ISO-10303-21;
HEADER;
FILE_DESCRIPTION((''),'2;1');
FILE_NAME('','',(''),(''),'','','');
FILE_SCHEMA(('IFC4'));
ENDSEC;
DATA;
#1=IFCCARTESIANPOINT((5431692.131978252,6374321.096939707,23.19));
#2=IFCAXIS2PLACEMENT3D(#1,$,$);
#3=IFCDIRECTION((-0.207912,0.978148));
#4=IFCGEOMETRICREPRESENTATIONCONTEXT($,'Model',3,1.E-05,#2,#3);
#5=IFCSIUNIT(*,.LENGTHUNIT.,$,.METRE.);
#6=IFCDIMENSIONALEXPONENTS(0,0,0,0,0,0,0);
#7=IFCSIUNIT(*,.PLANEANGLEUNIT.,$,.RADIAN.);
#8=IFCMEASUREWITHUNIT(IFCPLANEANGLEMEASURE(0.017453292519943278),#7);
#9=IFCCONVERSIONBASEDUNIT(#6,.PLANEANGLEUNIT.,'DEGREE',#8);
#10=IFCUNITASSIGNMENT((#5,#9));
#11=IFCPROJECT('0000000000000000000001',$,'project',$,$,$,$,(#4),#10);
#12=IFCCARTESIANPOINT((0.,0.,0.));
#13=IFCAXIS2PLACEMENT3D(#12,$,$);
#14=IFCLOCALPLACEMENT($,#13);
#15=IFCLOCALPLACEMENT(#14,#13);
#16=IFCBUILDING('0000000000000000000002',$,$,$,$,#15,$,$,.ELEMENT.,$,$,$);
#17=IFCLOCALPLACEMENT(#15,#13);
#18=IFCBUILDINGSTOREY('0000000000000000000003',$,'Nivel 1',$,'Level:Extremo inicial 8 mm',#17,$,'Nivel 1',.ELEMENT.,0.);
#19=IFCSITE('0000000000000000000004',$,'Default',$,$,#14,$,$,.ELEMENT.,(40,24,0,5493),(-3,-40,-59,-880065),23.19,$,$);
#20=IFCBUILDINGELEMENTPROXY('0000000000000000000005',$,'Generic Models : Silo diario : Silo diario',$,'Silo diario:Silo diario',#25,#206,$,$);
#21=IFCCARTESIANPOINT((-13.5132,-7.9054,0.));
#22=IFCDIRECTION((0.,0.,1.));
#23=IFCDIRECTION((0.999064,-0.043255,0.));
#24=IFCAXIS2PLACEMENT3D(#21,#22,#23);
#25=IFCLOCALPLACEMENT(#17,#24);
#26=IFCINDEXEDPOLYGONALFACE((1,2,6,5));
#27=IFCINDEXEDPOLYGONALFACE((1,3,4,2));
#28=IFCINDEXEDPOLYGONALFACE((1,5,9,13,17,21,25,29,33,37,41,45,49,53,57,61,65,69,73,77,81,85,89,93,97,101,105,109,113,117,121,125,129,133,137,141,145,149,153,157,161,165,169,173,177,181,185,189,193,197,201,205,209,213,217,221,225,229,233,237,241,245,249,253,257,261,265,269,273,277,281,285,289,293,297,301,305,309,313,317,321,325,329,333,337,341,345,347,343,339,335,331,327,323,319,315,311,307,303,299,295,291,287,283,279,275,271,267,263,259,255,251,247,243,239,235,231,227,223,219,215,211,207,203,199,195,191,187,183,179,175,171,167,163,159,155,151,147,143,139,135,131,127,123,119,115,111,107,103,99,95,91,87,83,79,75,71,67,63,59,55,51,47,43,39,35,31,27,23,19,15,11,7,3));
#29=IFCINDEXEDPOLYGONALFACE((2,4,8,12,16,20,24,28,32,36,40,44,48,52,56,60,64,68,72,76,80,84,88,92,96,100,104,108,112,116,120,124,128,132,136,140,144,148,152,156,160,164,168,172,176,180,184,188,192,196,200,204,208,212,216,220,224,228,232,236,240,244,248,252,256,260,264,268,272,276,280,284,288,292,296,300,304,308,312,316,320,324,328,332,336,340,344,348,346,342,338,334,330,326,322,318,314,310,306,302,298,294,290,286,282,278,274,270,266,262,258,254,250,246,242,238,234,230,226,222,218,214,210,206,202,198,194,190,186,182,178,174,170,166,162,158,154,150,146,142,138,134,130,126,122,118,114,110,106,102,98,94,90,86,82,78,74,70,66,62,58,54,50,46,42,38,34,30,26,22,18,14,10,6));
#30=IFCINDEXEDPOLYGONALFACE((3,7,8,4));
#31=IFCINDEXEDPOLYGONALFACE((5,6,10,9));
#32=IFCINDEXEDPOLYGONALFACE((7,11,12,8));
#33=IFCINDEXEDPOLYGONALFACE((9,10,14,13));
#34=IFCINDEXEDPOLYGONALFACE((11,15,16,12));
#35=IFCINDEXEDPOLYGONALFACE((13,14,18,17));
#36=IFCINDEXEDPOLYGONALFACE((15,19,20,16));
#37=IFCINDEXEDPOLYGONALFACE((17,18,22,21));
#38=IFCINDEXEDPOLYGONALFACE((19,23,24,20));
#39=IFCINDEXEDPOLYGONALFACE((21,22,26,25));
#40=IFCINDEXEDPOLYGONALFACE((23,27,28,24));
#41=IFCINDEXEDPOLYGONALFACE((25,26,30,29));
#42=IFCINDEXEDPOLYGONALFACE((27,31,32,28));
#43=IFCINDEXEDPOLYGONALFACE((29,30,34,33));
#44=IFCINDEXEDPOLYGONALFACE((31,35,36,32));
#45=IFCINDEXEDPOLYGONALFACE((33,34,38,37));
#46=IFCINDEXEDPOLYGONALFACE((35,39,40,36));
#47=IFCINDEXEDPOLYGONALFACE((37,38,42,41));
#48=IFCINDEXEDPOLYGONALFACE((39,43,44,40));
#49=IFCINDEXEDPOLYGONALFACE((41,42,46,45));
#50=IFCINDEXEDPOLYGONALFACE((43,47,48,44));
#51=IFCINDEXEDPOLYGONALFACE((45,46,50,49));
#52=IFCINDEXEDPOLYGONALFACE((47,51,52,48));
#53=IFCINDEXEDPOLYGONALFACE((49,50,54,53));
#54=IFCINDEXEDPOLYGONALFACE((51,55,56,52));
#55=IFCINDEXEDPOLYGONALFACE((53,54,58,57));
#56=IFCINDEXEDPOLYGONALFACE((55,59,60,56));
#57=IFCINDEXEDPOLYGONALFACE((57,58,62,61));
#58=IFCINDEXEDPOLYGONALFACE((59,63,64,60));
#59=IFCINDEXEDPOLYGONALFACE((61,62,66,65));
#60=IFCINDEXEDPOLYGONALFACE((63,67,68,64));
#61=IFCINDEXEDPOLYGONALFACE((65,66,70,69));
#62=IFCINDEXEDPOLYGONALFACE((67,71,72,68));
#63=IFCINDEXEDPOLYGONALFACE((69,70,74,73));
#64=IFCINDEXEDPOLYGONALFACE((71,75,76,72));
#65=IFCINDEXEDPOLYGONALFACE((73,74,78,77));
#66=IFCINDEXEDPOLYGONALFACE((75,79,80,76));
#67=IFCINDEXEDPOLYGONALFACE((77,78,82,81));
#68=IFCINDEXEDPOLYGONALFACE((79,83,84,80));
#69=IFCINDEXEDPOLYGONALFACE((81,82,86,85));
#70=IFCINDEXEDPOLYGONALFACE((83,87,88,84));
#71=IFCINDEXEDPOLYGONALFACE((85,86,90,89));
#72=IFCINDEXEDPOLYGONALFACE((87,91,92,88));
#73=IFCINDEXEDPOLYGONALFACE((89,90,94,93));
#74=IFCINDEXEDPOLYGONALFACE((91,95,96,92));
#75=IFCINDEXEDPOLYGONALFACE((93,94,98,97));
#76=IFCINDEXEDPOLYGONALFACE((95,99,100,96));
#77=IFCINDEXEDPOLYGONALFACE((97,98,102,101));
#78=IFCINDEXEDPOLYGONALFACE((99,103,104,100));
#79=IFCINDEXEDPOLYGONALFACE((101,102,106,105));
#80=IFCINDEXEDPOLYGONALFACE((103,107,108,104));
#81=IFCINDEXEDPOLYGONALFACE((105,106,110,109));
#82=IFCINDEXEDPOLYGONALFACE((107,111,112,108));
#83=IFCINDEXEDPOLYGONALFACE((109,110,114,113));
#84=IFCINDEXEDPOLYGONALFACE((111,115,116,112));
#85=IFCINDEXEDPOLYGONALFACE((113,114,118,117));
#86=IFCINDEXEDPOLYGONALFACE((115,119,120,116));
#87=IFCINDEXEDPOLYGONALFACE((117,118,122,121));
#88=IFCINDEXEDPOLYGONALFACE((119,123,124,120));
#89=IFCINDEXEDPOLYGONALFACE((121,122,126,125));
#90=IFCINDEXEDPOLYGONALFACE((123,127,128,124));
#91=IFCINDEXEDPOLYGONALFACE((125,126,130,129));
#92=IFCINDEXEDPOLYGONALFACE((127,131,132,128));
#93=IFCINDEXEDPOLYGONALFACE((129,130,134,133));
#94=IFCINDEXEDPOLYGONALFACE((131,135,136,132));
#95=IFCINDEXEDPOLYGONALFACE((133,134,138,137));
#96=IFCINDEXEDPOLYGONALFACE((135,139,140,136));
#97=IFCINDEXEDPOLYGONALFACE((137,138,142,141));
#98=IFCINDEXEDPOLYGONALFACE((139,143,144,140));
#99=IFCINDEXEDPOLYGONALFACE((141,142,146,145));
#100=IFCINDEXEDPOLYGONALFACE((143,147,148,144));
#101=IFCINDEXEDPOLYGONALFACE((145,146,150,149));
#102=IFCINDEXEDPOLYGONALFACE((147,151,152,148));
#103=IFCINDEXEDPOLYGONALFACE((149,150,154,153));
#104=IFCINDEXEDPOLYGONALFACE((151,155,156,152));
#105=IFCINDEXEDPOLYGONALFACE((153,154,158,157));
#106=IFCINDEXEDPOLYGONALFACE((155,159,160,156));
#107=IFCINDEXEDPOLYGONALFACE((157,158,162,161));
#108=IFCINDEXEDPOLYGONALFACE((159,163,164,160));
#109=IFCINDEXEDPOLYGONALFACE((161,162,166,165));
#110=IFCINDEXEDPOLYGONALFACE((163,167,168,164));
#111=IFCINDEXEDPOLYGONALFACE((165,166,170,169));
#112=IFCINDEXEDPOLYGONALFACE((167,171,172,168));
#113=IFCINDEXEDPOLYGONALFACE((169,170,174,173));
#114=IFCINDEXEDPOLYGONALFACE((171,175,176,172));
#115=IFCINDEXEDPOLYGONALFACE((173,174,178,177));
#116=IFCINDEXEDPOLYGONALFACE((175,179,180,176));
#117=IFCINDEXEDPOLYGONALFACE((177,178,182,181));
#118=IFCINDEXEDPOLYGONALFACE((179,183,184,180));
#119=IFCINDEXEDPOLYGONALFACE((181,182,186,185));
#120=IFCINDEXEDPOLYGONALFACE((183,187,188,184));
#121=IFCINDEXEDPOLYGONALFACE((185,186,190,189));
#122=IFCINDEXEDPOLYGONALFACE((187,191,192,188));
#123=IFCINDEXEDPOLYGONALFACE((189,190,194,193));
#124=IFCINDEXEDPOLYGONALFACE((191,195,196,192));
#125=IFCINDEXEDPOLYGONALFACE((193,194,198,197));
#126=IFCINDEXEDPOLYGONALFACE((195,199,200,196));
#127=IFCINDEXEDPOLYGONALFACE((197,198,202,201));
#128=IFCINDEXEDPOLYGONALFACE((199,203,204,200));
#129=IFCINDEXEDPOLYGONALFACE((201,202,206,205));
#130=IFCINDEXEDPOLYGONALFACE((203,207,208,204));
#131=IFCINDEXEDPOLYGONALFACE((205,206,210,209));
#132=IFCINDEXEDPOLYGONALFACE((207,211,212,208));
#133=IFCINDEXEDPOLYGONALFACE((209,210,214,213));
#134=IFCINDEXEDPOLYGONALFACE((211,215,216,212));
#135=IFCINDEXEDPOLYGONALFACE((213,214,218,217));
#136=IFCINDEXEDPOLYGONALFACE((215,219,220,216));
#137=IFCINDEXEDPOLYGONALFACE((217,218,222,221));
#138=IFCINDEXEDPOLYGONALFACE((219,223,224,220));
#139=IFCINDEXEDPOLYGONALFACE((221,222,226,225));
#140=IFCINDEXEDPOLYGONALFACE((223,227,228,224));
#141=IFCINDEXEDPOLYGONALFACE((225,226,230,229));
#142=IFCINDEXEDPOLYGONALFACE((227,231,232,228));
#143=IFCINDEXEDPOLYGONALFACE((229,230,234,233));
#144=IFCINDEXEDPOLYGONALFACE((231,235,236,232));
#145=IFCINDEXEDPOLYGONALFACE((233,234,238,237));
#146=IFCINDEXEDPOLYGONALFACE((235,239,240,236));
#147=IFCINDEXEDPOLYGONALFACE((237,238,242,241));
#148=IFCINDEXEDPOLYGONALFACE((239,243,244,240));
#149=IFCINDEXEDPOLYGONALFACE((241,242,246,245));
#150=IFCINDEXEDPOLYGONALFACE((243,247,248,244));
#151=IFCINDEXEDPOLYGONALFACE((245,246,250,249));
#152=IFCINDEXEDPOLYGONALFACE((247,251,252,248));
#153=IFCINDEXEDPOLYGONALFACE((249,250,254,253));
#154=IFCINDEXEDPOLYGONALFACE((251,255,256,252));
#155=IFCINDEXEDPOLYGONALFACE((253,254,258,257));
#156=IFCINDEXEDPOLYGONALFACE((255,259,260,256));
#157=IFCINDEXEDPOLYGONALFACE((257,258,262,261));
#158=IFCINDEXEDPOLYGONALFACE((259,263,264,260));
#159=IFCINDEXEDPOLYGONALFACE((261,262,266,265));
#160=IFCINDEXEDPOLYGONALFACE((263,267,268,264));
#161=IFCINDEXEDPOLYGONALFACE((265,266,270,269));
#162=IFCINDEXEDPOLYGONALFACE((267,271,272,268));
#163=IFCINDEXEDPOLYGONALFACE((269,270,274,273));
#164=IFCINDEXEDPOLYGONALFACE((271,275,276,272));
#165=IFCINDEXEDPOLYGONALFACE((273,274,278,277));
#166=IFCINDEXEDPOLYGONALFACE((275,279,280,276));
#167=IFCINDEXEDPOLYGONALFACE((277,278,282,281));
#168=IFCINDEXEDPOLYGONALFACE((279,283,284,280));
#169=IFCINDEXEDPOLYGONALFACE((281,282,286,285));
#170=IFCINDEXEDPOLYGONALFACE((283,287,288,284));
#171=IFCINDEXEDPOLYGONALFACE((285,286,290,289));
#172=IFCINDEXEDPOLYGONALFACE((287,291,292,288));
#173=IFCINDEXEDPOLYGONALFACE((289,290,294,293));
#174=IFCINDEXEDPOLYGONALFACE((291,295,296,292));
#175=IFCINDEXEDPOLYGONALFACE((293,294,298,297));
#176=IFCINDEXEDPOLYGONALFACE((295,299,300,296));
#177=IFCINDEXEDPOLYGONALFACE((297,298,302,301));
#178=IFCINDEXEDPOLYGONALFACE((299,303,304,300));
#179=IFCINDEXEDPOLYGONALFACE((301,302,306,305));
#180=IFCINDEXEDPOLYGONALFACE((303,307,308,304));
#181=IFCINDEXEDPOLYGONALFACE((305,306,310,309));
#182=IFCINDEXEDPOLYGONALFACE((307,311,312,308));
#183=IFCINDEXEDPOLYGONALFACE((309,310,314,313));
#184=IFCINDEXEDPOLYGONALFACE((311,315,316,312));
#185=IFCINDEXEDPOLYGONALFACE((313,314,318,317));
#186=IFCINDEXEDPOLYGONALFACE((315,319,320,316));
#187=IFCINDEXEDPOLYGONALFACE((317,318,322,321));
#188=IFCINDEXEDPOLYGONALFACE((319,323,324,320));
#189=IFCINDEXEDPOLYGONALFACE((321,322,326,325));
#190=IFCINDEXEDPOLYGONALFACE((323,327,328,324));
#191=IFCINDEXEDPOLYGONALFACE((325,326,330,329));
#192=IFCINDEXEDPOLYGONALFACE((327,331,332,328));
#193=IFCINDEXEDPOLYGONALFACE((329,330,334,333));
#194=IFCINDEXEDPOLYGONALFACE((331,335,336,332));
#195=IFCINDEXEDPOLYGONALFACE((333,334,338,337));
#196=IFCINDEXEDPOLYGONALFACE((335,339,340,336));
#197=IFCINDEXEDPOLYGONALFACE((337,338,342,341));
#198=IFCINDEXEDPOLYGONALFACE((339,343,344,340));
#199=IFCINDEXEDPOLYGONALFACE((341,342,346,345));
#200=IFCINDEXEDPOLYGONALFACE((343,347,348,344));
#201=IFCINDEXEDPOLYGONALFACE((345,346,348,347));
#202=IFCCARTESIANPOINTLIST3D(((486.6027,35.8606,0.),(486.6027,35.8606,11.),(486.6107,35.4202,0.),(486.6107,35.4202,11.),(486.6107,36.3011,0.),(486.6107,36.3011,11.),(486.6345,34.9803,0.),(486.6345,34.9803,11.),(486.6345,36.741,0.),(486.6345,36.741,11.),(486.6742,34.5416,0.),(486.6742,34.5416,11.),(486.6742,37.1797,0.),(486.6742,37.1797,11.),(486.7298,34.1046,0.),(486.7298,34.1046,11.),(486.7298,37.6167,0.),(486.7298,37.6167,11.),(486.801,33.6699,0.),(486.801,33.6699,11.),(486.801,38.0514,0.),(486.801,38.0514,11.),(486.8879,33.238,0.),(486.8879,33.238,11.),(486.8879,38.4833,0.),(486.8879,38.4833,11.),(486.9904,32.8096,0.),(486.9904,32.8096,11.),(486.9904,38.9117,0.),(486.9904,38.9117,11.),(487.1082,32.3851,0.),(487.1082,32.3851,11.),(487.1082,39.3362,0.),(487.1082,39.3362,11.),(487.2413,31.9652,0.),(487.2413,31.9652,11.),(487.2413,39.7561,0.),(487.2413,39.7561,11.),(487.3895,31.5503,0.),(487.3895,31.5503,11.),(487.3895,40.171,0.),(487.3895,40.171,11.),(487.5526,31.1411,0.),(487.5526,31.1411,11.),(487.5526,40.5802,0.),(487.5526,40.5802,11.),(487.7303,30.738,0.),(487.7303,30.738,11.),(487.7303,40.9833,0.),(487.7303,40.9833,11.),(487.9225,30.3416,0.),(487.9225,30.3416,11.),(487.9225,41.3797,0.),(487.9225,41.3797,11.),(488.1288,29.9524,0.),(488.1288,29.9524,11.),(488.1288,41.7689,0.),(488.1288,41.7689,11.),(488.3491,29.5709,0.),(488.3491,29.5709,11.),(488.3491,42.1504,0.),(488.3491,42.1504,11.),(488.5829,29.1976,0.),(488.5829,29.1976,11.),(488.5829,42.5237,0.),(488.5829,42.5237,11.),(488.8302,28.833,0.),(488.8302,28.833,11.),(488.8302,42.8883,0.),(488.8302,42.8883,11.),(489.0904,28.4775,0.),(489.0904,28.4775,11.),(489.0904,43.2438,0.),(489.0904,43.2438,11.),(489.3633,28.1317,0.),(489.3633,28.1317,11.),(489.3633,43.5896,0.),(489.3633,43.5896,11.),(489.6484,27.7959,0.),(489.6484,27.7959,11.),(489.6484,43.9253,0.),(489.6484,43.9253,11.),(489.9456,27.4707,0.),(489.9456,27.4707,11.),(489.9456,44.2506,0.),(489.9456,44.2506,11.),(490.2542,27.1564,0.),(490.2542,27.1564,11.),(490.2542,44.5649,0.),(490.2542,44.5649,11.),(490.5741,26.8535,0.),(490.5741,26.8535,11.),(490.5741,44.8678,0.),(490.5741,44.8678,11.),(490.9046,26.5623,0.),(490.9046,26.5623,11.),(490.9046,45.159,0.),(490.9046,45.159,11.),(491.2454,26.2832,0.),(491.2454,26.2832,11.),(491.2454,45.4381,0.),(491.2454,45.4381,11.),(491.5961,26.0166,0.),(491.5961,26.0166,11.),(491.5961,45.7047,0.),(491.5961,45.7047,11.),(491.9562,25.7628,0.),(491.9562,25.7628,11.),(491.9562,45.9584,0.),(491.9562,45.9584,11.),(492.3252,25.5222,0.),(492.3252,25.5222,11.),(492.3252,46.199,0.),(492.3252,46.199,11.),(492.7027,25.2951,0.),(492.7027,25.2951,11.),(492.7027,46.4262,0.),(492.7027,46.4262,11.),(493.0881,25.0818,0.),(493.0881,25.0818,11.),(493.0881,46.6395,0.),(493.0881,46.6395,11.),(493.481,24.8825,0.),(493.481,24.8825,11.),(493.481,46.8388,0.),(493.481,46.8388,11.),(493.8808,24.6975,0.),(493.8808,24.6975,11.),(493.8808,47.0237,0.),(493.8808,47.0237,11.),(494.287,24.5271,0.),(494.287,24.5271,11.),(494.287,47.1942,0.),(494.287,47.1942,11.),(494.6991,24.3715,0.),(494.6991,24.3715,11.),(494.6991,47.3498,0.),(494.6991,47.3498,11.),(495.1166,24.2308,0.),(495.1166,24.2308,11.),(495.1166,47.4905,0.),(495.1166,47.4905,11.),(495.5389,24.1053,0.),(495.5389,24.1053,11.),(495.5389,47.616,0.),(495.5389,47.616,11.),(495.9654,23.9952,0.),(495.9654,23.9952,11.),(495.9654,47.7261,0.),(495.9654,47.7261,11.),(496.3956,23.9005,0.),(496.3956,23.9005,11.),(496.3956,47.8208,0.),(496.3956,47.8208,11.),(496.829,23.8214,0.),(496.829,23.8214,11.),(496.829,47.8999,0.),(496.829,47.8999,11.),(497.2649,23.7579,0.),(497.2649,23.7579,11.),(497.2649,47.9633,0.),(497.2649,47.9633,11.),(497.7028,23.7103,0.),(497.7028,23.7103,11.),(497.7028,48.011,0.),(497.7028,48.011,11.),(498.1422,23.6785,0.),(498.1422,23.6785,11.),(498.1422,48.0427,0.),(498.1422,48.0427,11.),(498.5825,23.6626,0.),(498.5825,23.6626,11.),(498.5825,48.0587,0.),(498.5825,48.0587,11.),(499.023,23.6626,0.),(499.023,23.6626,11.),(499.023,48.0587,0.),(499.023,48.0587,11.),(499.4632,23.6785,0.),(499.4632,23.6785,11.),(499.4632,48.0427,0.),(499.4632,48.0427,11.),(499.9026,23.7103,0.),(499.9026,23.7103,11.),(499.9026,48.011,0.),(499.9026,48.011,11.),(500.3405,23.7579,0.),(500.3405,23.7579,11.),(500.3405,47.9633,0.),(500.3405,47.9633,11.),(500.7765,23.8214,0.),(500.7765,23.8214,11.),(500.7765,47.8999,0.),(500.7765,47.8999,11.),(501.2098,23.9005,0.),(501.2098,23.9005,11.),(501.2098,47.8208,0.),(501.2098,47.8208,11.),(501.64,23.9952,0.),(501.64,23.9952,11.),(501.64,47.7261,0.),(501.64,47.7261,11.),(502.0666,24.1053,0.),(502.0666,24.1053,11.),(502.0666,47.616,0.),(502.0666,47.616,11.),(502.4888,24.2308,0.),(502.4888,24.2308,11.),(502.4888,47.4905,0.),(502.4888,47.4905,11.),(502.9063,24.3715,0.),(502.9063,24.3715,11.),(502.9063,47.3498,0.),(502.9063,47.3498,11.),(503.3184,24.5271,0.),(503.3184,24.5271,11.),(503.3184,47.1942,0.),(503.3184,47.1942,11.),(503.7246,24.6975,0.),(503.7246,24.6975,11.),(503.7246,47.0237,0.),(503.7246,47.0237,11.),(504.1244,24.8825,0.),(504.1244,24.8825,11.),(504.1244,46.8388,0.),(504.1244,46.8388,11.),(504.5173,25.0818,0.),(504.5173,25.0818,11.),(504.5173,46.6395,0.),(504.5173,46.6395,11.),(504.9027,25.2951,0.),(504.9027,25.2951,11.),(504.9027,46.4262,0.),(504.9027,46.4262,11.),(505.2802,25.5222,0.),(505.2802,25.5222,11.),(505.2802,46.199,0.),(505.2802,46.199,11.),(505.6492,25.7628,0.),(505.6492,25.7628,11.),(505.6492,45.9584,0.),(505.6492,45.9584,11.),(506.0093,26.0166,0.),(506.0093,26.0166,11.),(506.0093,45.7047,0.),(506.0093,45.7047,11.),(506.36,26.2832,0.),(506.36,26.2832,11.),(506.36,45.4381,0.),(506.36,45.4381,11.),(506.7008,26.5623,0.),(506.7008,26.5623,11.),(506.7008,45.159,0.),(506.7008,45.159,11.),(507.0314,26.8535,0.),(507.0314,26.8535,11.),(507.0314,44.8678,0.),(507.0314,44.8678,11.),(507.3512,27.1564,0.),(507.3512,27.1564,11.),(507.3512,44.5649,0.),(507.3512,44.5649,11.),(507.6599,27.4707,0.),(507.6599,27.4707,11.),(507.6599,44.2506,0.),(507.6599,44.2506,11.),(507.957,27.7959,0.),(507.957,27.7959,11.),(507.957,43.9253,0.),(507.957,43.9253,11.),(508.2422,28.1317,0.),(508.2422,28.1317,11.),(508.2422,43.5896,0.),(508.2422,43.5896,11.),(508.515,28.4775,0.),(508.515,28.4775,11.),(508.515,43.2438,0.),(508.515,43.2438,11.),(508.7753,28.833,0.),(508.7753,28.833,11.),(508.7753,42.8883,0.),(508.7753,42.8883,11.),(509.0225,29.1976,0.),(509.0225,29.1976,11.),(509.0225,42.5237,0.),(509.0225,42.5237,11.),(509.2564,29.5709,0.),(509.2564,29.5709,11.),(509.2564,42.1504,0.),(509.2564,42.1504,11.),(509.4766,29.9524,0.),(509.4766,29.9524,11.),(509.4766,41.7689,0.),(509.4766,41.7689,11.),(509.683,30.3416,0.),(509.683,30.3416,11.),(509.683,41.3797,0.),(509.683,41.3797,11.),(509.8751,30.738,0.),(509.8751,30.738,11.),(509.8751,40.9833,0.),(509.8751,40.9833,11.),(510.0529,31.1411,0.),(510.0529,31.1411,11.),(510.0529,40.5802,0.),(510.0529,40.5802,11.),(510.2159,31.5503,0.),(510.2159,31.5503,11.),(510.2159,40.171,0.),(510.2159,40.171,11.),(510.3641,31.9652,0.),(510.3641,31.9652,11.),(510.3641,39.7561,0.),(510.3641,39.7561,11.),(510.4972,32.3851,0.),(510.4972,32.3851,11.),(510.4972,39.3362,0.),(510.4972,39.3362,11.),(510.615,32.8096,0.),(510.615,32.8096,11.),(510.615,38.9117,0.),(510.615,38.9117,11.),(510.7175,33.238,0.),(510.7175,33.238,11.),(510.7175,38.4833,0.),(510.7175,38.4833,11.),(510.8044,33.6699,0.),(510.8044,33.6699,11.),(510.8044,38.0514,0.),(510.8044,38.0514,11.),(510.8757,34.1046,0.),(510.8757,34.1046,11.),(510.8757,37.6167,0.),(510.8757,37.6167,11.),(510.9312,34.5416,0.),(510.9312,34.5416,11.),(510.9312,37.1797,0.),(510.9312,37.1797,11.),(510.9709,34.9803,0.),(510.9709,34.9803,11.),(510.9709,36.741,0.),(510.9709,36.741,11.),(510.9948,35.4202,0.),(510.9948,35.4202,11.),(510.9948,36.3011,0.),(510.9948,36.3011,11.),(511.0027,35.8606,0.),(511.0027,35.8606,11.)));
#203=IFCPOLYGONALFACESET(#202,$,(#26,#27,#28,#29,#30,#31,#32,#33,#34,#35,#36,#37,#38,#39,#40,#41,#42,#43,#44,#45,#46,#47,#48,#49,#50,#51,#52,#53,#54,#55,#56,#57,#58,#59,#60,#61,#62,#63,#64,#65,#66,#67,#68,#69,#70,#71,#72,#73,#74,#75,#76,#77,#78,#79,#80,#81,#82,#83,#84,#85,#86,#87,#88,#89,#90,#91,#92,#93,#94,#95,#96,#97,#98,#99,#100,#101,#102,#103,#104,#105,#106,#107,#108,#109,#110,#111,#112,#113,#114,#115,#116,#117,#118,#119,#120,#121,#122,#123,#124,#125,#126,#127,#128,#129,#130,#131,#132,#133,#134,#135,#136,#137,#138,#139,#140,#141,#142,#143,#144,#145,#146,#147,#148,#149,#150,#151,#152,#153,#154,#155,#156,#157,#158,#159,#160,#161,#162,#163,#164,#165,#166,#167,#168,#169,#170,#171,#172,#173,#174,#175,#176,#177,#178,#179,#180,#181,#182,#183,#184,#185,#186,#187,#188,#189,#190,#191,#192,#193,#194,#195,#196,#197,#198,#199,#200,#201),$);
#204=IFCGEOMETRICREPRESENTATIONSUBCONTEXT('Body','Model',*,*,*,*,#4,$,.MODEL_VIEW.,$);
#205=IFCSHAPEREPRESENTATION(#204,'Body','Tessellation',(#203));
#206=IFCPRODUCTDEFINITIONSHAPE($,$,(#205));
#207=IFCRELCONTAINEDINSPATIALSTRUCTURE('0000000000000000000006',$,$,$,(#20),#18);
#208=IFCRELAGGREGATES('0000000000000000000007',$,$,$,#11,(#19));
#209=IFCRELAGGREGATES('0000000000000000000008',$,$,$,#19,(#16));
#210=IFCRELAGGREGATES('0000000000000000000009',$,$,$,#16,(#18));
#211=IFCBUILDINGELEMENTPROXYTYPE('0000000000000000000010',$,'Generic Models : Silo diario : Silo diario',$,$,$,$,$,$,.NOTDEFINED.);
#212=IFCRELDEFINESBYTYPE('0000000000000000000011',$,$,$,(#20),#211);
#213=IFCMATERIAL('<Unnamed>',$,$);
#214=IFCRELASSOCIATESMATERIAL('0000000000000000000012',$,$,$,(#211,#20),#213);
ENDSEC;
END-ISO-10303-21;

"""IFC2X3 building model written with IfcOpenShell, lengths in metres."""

from ifc_helpers import new_model, entity, si_unit, converted_unit, direction, frame, frame_2d, origin, place, context, subcontext, project, spatial, circle, extrude, source, transform, mapped, material, type_object, type_shapes, element, save


model = new_model("IFC2X3")

# Units and contexts
model_context = context("Model", 3, precision=1e-05, world=frame((5431692.131978252, 6374321.096939707, 23.19)), true_north=direction((-0.207912, 0.978148)))
body_context = subcontext(model_context, "Body", "Model", "MODEL_VIEW")
ifc_project = project(units=[si_unit("LENGTHUNIT", "METRE"), converted_unit("PLANEANGLEUNIT", "DEGREE", entity("IfcPlaneAngleMeasure", 0.017453292519943278), si_unit("PLANEANGLEUNIT", "RADIAN"), dimensions=[0, 0, 0, 0, 0, 0, 0])], contexts=[model_context])

# Site, building, storey
site_placement = place(None, origin())
site = spatial("IfcSite", under=ifc_project, at=site_placement, Name="Default", CompositionType="ELEMENT", RefLatitude=(40, 24, 0, 5493), RefLongitude=(-3, -40, -59, -880065), RefElevation=23.19)
building_placement = place(site_placement, origin())
building = spatial("IfcBuilding", under=site, at=building_placement, CompositionType="ELEMENT")
storey_placement = place(building_placement, origin())
storey = spatial("IfcBuildingStorey", under=building, at=storey_placement, Name="Nivel 1", ObjectType="Level:Extremo inicial 8 mm", LongName="Nivel 1", CompositionType="ELEMENT", Elevation=0.0)

# Building element proxy
ifc_material_1 = material(Name="<Unnamed>")
building_element_proxy_type_1 = type_object("IfcBuildingElementProxyType", Name="Generic Models : Silo diario : Silo diario", PredefinedType="NOTDEFINED", material=ifc_material_1)
shared_shape_1 = source(origin(), body_context, "Body", "SweptSolid", [
    extrude(circle(Radius=12.2, at=frame_2d((0.0, 0.0), x_axis=(1.0, 0.0))), frame((498.8027, 35.8606, 0.0)), (0.0, 0.0, 1.0), 11.0),
])
type_shapes(building_element_proxy_type_1, [shared_shape_1])
proxy_1_placement = place(storey_placement, frame((-13.5132, -7.9054, 0.0), z_axis=(0.0, 0.0, 1.0), x_axis=(0.999064, -0.043255, 0.0)))
element("IfcBuildingElementProxy", 1, at=proxy_1_placement, inside=storey, type_object=building_element_proxy_type_1, material=ifc_material_1, Name="Generic Models : Silo diario : Silo diario", ObjectType="Silo diario:Silo diario", context=body_context, shape_type="MappedRepresentation", body=[
    mapped(shared_shape_1, transform((0.0, 0.0, 0.0), scale=1.0)),
])

save(model, "model.ifc")
